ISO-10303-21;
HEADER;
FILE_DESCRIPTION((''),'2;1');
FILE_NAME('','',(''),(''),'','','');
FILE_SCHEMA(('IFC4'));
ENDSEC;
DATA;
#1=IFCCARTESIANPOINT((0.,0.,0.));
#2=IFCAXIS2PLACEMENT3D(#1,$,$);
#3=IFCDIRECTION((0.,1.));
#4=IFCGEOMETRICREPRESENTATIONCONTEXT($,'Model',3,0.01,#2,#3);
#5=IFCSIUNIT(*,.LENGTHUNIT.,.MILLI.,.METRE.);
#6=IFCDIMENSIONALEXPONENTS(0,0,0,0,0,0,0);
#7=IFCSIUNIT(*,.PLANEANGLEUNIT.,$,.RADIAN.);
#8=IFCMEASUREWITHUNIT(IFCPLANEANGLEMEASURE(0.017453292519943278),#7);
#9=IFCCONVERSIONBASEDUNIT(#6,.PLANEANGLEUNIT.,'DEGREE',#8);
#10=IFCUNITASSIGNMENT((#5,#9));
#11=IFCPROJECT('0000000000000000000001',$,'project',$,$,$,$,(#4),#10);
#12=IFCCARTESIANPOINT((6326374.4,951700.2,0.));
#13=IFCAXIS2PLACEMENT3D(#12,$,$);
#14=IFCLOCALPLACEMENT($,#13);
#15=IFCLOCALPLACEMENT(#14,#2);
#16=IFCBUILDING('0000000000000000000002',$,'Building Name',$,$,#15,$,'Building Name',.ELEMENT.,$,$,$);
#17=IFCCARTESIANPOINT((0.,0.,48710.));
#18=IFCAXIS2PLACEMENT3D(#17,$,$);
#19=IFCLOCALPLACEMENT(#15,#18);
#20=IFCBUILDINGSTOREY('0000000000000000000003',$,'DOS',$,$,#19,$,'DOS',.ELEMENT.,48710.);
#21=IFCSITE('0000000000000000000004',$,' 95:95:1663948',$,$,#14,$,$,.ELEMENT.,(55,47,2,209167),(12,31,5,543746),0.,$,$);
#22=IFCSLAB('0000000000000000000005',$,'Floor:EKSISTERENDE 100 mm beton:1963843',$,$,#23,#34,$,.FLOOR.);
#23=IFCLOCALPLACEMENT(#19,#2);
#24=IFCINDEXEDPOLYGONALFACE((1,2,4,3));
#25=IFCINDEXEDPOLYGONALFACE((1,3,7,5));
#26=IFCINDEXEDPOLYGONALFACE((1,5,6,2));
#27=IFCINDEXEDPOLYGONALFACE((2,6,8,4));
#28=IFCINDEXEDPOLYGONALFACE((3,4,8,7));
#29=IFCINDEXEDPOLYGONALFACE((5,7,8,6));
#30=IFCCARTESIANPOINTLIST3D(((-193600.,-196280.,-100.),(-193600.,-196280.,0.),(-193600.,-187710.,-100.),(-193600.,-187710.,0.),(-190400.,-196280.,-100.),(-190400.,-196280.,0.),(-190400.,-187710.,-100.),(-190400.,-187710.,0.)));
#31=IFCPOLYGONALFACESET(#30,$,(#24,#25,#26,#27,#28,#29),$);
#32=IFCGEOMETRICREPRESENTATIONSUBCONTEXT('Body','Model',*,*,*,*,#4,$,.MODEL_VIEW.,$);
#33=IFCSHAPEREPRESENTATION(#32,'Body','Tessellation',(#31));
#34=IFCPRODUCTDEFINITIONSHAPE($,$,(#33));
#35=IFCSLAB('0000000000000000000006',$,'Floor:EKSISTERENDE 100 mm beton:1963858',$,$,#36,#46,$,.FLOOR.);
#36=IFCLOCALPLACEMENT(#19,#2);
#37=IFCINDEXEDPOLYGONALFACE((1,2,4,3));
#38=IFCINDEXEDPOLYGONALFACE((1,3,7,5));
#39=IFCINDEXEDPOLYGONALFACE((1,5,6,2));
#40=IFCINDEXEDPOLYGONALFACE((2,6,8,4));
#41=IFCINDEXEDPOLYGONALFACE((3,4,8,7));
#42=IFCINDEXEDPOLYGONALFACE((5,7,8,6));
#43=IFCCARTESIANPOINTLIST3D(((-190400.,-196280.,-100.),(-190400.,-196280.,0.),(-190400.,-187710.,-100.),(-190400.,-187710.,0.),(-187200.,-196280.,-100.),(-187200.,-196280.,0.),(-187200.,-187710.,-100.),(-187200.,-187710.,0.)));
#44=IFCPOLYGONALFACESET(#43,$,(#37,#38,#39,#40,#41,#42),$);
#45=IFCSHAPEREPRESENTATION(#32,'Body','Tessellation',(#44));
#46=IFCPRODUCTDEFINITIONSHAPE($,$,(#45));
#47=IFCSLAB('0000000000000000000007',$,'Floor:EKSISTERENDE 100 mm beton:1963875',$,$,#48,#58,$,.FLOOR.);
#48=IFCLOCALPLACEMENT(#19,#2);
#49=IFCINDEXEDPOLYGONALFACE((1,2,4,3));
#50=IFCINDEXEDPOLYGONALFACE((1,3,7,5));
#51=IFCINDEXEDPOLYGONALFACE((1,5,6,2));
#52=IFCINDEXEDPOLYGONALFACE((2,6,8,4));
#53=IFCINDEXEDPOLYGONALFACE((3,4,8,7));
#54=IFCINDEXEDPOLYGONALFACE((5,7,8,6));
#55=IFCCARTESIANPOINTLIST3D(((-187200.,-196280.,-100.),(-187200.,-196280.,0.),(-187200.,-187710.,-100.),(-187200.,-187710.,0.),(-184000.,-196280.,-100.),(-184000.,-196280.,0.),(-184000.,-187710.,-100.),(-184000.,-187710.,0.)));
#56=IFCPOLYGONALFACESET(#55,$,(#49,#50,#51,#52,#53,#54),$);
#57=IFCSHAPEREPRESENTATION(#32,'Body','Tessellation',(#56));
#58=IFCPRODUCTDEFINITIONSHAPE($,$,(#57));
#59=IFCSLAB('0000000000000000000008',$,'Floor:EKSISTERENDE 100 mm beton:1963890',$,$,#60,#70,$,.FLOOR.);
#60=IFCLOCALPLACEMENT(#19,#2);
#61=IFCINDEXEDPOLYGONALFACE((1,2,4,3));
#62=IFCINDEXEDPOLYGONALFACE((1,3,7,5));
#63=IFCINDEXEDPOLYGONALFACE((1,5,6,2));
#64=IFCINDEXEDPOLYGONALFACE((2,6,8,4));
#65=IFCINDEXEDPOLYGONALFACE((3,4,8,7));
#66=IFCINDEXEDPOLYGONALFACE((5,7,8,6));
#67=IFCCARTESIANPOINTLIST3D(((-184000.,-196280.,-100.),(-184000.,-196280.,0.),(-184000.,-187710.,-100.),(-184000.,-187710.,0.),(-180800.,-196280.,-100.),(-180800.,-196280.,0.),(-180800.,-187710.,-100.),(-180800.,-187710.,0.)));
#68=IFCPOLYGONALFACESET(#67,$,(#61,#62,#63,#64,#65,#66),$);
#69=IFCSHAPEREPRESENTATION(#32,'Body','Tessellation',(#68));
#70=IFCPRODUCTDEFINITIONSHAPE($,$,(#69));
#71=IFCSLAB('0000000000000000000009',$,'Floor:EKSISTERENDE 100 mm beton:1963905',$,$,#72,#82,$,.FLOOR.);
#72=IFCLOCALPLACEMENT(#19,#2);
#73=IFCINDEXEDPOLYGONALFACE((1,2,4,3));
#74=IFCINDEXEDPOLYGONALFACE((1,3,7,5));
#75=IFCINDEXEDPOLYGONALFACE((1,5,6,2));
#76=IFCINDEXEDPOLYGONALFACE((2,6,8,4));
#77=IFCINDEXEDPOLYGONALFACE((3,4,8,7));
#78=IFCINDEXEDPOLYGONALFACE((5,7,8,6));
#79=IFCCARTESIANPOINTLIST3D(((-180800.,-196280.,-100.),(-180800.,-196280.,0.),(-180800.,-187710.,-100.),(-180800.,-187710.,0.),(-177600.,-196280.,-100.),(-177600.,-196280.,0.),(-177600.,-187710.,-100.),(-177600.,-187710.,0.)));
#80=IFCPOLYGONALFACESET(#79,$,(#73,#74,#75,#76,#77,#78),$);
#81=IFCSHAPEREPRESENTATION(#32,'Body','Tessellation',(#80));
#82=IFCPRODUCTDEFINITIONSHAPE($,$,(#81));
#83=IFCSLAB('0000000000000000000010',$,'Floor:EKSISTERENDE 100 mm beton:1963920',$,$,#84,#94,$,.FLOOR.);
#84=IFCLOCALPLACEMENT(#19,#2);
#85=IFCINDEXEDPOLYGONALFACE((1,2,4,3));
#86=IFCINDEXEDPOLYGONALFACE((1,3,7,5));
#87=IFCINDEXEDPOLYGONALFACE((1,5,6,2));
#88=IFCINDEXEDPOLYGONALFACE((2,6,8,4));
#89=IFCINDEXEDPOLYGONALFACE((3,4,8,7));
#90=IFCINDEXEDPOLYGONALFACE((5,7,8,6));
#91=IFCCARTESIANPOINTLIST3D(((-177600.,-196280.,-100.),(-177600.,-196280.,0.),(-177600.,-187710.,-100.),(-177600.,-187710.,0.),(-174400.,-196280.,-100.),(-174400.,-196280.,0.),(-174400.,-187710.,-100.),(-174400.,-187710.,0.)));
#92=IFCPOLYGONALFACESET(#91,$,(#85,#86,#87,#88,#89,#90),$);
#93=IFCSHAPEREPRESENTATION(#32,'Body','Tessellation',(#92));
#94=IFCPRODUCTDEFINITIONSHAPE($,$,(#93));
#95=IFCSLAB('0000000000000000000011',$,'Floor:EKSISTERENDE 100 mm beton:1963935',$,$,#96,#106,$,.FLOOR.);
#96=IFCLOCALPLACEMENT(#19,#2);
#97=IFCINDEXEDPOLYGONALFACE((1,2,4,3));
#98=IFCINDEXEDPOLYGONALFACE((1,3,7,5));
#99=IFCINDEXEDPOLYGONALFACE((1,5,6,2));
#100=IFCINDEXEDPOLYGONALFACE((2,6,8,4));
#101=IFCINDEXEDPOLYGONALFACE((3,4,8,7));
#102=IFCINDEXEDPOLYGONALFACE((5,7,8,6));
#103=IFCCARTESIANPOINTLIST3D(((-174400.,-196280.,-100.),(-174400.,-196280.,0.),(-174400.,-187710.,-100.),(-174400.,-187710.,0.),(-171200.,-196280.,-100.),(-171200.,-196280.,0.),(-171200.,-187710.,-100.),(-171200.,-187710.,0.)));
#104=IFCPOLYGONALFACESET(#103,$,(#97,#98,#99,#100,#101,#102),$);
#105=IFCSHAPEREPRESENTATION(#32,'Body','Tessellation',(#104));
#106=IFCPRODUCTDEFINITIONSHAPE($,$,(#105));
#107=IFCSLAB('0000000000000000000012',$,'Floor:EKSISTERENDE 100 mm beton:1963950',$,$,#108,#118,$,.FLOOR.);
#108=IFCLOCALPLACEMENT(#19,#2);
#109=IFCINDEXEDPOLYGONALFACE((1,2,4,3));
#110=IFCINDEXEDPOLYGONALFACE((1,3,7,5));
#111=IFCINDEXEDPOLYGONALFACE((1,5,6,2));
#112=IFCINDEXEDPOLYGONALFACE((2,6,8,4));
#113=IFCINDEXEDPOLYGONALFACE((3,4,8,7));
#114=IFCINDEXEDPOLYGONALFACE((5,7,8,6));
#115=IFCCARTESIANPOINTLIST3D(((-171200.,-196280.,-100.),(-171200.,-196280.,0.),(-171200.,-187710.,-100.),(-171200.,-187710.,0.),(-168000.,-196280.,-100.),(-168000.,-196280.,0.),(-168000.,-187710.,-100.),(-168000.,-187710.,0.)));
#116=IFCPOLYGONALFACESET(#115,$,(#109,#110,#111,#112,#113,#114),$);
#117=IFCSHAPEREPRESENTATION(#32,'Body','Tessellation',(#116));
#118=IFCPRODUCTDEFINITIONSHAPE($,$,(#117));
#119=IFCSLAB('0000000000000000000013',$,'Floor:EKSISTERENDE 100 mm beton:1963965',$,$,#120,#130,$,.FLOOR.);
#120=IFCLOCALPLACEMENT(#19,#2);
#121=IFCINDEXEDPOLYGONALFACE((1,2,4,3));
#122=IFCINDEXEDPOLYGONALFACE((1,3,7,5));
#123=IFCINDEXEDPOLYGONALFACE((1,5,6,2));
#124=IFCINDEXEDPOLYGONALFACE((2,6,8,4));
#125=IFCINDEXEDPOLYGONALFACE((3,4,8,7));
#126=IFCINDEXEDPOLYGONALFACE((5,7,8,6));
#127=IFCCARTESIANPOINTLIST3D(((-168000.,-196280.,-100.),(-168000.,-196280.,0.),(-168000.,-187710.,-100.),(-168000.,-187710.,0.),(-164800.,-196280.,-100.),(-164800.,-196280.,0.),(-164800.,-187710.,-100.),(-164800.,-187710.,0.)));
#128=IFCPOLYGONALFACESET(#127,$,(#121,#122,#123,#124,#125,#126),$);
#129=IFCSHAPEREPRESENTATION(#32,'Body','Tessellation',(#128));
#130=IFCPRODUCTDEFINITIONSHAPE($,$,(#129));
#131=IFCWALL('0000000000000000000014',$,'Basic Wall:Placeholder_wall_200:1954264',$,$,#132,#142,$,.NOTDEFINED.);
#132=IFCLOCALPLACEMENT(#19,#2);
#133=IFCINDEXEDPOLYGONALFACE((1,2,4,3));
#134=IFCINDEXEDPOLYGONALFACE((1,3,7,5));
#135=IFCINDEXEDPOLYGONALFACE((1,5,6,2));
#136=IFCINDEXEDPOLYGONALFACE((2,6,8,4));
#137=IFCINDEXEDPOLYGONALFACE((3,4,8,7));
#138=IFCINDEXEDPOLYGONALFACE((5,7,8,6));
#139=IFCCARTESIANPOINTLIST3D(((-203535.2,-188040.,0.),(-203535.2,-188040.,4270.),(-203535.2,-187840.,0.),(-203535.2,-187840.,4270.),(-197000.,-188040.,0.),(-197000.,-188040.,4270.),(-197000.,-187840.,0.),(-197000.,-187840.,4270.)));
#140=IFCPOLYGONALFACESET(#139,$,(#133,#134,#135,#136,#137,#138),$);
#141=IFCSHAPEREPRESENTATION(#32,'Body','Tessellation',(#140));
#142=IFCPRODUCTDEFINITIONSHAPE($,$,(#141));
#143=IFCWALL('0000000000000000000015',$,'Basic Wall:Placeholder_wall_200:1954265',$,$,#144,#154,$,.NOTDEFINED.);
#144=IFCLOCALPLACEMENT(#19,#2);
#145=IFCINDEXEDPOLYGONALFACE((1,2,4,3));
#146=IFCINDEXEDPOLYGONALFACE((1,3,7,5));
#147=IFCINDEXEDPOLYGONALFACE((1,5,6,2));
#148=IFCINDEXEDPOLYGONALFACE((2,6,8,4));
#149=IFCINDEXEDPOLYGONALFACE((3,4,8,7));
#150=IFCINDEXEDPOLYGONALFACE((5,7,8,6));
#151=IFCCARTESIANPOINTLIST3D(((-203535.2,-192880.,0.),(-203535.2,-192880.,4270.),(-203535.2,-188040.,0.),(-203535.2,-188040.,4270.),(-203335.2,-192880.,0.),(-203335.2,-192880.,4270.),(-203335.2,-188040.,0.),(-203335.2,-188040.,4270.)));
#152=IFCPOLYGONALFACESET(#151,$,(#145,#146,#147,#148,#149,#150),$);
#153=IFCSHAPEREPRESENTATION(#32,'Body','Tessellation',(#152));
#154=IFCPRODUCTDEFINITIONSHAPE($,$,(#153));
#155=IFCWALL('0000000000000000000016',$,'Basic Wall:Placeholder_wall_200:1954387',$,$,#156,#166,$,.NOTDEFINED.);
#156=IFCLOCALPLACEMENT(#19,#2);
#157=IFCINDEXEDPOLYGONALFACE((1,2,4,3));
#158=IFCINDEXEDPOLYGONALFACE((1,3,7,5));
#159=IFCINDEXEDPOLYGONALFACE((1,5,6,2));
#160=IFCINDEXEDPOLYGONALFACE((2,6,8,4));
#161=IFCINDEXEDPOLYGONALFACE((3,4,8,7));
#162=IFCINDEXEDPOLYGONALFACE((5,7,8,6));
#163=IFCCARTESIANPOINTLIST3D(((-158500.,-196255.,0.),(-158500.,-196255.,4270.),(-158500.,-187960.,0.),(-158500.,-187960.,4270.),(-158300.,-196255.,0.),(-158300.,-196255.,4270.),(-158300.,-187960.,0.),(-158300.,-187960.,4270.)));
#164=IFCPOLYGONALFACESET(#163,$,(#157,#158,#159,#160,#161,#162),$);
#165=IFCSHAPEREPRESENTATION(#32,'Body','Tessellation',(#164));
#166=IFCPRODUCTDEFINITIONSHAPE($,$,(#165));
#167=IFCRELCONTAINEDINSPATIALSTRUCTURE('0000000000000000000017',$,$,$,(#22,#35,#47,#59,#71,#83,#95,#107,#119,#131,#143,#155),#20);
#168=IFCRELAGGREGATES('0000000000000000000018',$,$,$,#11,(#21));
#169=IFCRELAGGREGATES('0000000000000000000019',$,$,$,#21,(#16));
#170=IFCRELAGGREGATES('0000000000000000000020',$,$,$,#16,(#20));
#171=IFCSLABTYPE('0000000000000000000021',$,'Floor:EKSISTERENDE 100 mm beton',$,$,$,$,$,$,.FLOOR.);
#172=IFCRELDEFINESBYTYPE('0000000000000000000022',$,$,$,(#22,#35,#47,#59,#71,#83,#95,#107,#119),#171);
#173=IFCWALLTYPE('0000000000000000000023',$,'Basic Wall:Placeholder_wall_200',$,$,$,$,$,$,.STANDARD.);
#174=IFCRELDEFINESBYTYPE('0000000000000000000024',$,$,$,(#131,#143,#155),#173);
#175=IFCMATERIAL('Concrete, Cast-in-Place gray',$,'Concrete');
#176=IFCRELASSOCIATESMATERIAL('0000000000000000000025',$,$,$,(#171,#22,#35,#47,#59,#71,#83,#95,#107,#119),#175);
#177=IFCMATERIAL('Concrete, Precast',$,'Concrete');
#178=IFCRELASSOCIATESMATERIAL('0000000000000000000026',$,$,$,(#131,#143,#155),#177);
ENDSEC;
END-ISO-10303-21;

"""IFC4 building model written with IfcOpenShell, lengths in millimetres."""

from ifc_helpers import new_model, entity, si_unit, converted_unit, direction, frame, origin, place, context, subcontext, project, spatial, indexed_curve, outline, extrude, material, type_object, element, save


model = new_model("IFC4")

# Units and contexts
model_context = context("Model", 3, precision=0.01, world=origin(), true_north=direction((0.0, 1.0)))
body_context = subcontext(model_context, "Body", "Model", "MODEL_VIEW")
ifc_project = project(units=[si_unit("LENGTHUNIT", "METRE", prefix="MILLI"), converted_unit("PLANEANGLEUNIT", "DEGREE", entity("IfcPlaneAngleMeasure", 0.017453292519943278), si_unit("PLANEANGLEUNIT", "RADIAN"), dimensions=[0, 0, 0, 0, 0, 0, 0])], contexts=[model_context])

# Site, building, storey
site_placement = place(None, frame((6326374.4, 951700.2, 0.0)))
site = spatial("IfcSite", under=ifc_project, at=site_placement, Name=" 95:95:1663948", CompositionType="ELEMENT", RefLatitude=(55, 47, 2, 209167), RefLongitude=(12, 31, 5, 543746), RefElevation=0.0)
building_placement = place(site_placement, origin())
building = spatial("IfcBuilding", under=site, at=building_placement, Name="Building Name", LongName="Building Name", CompositionType="ELEMENT")
storey_placement = place(building_placement, frame((0.0, 0.0, 48710.0)))
storey = spatial("IfcBuildingStorey", under=building, at=storey_placement, Name="DOS", LongName="DOS", CompositionType="ELEMENT", Elevation=48710.0)

# Shared definitions
ifc_material_1 = material(Name="Concrete, Precast", Category="Concrete")

# Slabs
ifc_material_2 = material(Name="Concrete, Cast-in-Place gray", Category="Concrete")
slab_type_1 = type_object("IfcSlabType", Name="Floor:EKSISTERENDE 100 mm beton", PredefinedType="FLOOR", material=ifc_material_2)
slab_1_placement = place(storey_placement, origin())
element("IfcSlab", 1, at=slab_1_placement, inside=storey, type_object=slab_type_1, material=ifc_material_2, Name="Floor:EKSISTERENDE 100 mm beton:1963843", PredefinedType="FLOOR", context=body_context, shape_type="SweptSolid", body=[
    extrude(outline(indexed_curve([(-4285.0, -1600.0), (4285.0, -1600.0), (4285.0, 1600.0), (-4285.0, 1600.0), (-4285.0, -1600.0)], self_intersect=False)), frame((-192000.0, -191995.0, 0.0), z_axis=(0.0, 0.0, -1.0), x_axis=(0.0, 1.0, 0.0)), (0.0, 0.0, 1.0), 100.0),
])
slab_2_placement = place(storey_placement, origin())
element("IfcSlab", 2, at=slab_2_placement, inside=storey, type_object=slab_type_1, material=ifc_material_2, Name="Floor:EKSISTERENDE 100 mm beton:1963858", PredefinedType="FLOOR", context=body_context, shape_type="SweptSolid", body=[
    extrude(outline(indexed_curve([(-4285.0, -1600.0), (4285.0, -1600.0), (4285.0, 1600.0), (-4285.0, 1600.0), (-4285.0, -1600.0)], self_intersect=False)), frame((-188800.0, -191995.0, 0.0), z_axis=(0.0, 0.0, -1.0), x_axis=(0.0, 1.0, 0.0)), (0.0, 0.0, 1.0), 100.0),
])
slab_3_placement = place(storey_placement, origin())
element("IfcSlab", 3, at=slab_3_placement, inside=storey, type_object=slab_type_1, material=ifc_material_2, Name="Floor:EKSISTERENDE 100 mm beton:1963875", PredefinedType="FLOOR", context=body_context, shape_type="SweptSolid", body=[
    extrude(outline(indexed_curve([(-4285.0, -1600.0), (4285.0, -1600.0), (4285.0, 1600.0), (-4285.0, 1600.0), (-4285.0, -1600.0)], self_intersect=False)), frame((-185600.0, -191995.0, 0.0), z_axis=(0.0, 0.0, -1.0), x_axis=(0.0, 1.0, 0.0)), (0.0, 0.0, 1.0), 100.0),
])
slab_4_placement = place(storey_placement, origin())
element("IfcSlab", 4, at=slab_4_placement, inside=storey, type_object=slab_type_1, material=ifc_material_2, Name="Floor:EKSISTERENDE 100 mm beton:1963890", PredefinedType="FLOOR", context=body_context, shape_type="SweptSolid", body=[
    extrude(outline(indexed_curve([(-4285.0, -1600.0), (4285.0, -1600.0), (4285.0, 1600.0), (-4285.0, 1600.0), (-4285.0, -1600.0)], self_intersect=False)), frame((-182400.0, -191995.0, 0.0), z_axis=(0.0, 0.0, -1.0), x_axis=(0.0, 1.0, 0.0)), (0.0, 0.0, 1.0), 100.0),
])
slab_5_placement = place(storey_placement, origin())
element("IfcSlab", 5, at=slab_5_placement, inside=storey, type_object=slab_type_1, material=ifc_material_2, Name="Floor:EKSISTERENDE 100 mm beton:1963905", PredefinedType="FLOOR", context=body_context, shape_type="SweptSolid", body=[
    extrude(outline(indexed_curve([(-4285.0, -1600.0), (4285.0, -1600.0), (4285.0, 1600.0), (-4285.0, 1600.0), (-4285.0, -1600.0)], self_intersect=False)), frame((-179200.0, -191995.0, 0.0), z_axis=(0.0, 0.0, -1.0), x_axis=(0.0, 1.0, 0.0)), (0.0, 0.0, 1.0), 100.0),
])
slab_6_placement = place(storey_placement, origin())
element("IfcSlab", 6, at=slab_6_placement, inside=storey, type_object=slab_type_1, material=ifc_material_2, Name="Floor:EKSISTERENDE 100 mm beton:1963920", PredefinedType="FLOOR", context=body_context, shape_type="SweptSolid", body=[
    extrude(outline(indexed_curve([(-4285.0, -1600.0), (4285.0, -1600.0), (4285.0, 1600.0), (-4285.0, 1600.0), (-4285.0, -1600.0)], self_intersect=False)), frame((-176000.0, -191995.0, 0.0), z_axis=(0.0, 0.0, -1.0), x_axis=(0.0, 1.0, 0.0)), (0.0, 0.0, 1.0), 100.0),
])
slab_7_placement = place(storey_placement, origin())
element("IfcSlab", 7, at=slab_7_placement, inside=storey, type_object=slab_type_1, material=ifc_material_2, Name="Floor:EKSISTERENDE 100 mm beton:1963935", PredefinedType="FLOOR", context=body_context, shape_type="SweptSolid", body=[
    extrude(outline(indexed_curve([(-4285.0, -1600.0), (4285.0, -1600.0), (4285.0, 1600.0), (-4285.0, 1600.0), (-4285.0, -1600.0)], self_intersect=False)), frame((-172800.0, -191995.0, 0.0), z_axis=(0.0, 0.0, -1.0), x_axis=(0.0, 1.0, 0.0)), (0.0, 0.0, 1.0), 100.0),
])
slab_8_placement = place(storey_placement, origin())
element("IfcSlab", 8, at=slab_8_placement, inside=storey, type_object=slab_type_1, material=ifc_material_2, Name="Floor:EKSISTERENDE 100 mm beton:1963950", PredefinedType="FLOOR", context=body_context, shape_type="SweptSolid", body=[
    extrude(outline(indexed_curve([(-4285.0, -1600.0), (4285.0, -1600.0), (4285.0, 1600.0), (-4285.0, 1600.0), (-4285.0, -1600.0)], self_intersect=False)), frame((-169600.0, -191995.0, 0.0), z_axis=(0.0, 0.0, -1.0), x_axis=(0.0, 1.0, 0.0)), (0.0, 0.0, 1.0), 100.0),
])
slab_9_placement = place(storey_placement, origin())
element("IfcSlab", 9, at=slab_9_placement, inside=storey, type_object=slab_type_1, material=ifc_material_2, Name="Floor:EKSISTERENDE 100 mm beton:1963965", PredefinedType="FLOOR", context=body_context, shape_type="SweptSolid", body=[
    extrude(outline(indexed_curve([(-4285.0, -1600.0), (4285.0, -1600.0), (4285.0, 1600.0), (-4285.0, 1600.0), (-4285.0, -1600.0)], self_intersect=False)), frame((-166400.0, -191995.0, 0.0), z_axis=(0.0, 0.0, -1.0), x_axis=(0.0, 1.0, 0.0)), (0.0, 0.0, 1.0), 100.0),
])

# Walls
wall_type = type_object("IfcWallType", Name="Basic Wall:Placeholder_wall_200", PredefinedType="STANDARD")
wall_1_placement = place(storey_placement, frame((-197000.0, -187940.0, 0.0), z_axis=(0.0, 0.0, 1.0), x_axis=(-1.0, 0.0, 0.0)))
element("IfcWall", 10, at=wall_1_placement, inside=storey, type_object=wall_type, material=ifc_material_1, Name="Basic Wall:Placeholder_wall_200:1954264", PredefinedType="NOTDEFINED", context=body_context, shape_type="SweptSolid", body=[
    extrude(outline(indexed_curve([(6535.2, 100.0), (0.0, 100.0), (0.0, -100.0), (6535.2, -100.0), (6535.2, 100.0)], self_intersect=False)), origin(), (0.0, 0.0, 1.0), 4270.0),
])
wall_2_placement = place(storey_placement, frame((-203435.2, -188040.0, 0.0), z_axis=(0.0, 0.0, 1.0), x_axis=(0.0, -1.0, 0.0)))
element("IfcWall", 11, at=wall_2_placement, inside=storey, type_object=wall_type, material=ifc_material_1, Name="Basic Wall:Placeholder_wall_200:1954265", PredefinedType="NOTDEFINED", context=body_context, shape_type="SweptSolid", body=[
    extrude(outline(indexed_curve([(4840.0, 100.0), (0.0, 100.0), (0.0, -100.0), (4840.0, -100.0), (4840.0, 100.0)], self_intersect=False)), origin(), (0.0, 0.0, 1.0), 4270.0),
])
wall_3_placement = place(storey_placement, frame((-158400.0, -187960.0, 0.0), z_axis=(0.0, 0.0, 1.0), x_axis=(0.0, -1.0, 0.0)))
element("IfcWall", 12, at=wall_3_placement, inside=storey, type_object=wall_type, material=ifc_material_1, Name="Basic Wall:Placeholder_wall_200:1954387", PredefinedType="NOTDEFINED", context=body_context, shape_type="SweptSolid", body=[
    extrude(outline(indexed_curve([(8295.0, 100.0), (0.0, 100.0), (0.0, -100.0), (8295.0, -100.0), (8295.0, 100.0)], self_intersect=False)), origin(), (0.0, 0.0, 1.0), 4270.0),
])

save(model, "model.ifc")
